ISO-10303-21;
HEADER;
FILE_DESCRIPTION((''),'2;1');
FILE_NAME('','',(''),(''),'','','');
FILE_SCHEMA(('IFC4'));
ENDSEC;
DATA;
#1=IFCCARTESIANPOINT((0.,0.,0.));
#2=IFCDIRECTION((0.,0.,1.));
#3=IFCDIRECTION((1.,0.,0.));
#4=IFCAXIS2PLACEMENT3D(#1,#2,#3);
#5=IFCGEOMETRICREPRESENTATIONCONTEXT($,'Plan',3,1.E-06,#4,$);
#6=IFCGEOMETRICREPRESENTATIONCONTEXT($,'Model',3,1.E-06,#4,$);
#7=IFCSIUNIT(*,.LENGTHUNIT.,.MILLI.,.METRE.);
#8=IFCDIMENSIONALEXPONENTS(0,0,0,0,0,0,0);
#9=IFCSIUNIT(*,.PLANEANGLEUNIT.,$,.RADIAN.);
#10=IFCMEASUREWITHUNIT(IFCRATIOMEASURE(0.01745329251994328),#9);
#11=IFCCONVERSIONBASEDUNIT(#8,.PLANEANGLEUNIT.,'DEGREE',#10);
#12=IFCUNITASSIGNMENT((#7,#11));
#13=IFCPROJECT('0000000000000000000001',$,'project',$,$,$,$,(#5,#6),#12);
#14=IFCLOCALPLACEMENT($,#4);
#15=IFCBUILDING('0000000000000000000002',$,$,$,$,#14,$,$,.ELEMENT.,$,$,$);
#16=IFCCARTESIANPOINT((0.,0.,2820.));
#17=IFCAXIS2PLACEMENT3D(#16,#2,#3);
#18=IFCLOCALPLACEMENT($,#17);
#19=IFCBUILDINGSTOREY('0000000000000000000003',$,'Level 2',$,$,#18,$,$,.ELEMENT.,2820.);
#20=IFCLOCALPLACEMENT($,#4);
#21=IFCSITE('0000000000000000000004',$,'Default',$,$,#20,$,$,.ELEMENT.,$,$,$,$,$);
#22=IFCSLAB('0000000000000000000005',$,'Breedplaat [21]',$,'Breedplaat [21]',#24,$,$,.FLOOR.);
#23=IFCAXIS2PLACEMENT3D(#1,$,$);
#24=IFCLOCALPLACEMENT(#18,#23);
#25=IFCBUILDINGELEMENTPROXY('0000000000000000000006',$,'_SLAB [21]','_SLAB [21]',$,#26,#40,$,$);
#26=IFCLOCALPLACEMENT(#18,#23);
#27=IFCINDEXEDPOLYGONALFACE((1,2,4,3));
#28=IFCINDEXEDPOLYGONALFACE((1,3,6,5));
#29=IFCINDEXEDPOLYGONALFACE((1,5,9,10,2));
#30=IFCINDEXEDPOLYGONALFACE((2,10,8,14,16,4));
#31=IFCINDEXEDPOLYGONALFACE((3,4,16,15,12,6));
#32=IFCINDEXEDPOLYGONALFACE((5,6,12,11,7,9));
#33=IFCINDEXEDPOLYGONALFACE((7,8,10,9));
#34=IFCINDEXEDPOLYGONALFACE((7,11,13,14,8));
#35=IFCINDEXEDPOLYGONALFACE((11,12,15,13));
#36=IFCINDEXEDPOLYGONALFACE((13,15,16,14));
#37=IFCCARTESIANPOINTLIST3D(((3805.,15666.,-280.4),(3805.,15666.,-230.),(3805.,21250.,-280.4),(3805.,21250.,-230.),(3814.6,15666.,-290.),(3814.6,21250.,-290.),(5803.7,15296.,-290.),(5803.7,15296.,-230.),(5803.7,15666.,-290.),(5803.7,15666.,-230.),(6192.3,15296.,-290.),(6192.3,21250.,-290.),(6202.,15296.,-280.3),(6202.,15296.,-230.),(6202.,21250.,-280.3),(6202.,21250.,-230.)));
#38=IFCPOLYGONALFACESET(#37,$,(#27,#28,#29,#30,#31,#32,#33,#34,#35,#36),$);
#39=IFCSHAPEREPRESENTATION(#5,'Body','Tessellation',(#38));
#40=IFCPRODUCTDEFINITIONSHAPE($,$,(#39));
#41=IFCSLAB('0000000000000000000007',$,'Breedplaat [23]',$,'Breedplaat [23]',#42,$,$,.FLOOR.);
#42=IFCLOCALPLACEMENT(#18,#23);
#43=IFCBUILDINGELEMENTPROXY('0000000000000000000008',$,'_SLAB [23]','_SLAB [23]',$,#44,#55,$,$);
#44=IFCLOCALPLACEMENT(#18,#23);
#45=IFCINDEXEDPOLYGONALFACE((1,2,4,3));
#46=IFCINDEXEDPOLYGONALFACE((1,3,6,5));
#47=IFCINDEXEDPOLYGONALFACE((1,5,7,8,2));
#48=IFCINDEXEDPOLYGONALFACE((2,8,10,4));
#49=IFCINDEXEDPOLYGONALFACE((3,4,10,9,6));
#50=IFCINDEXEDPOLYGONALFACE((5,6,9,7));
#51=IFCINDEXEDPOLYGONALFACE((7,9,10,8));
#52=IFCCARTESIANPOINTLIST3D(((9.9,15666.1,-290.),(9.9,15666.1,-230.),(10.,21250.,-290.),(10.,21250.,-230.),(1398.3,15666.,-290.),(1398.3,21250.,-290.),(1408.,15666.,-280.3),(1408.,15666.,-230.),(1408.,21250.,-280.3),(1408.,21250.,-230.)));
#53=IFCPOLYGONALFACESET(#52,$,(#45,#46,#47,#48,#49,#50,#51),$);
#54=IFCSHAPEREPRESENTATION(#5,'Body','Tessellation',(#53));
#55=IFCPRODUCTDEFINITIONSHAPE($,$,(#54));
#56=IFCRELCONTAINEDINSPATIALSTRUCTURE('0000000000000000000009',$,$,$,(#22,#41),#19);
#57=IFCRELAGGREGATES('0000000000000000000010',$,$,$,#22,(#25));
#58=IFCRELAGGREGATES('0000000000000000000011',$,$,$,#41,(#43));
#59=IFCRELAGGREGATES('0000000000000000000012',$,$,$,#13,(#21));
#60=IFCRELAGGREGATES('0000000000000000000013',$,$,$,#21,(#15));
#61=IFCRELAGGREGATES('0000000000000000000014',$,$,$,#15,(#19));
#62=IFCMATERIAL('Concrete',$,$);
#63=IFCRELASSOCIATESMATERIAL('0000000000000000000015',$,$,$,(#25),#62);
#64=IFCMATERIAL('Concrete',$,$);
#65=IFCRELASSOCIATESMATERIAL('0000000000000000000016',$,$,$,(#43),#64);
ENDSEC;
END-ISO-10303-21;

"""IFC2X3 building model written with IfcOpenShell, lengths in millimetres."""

from ifc_helpers import new_model, entity, si_unit, converted_unit, frame, origin_with_axes, place, context, project, spatial, polyline, outline, extrude, material, element, aggregate, save


model = new_model("IFC2X3")

# Units and contexts
plan_context = context("Plan", 3, precision=1e-06, world=origin_with_axes())
model_context = context("Model", 3, precision=1e-06, world=origin_with_axes())
ifc_project = project(units=[si_unit("LENGTHUNIT", "METRE", prefix="MILLI"), converted_unit("PLANEANGLEUNIT", "DEGREE", entity("IfcRatioMeasure", 0.01745329251994328), si_unit("PLANEANGLEUNIT", "RADIAN"), dimensions=[0, 0, 0, 0, 0, 0, 0])], contexts=[plan_context, model_context])

# Site, building, storey
site_placement = place(None, origin_with_axes())
site = spatial("IfcSite", under=ifc_project, at=site_placement, Name="Default", CompositionType="ELEMENT")
building_placement = place(None, origin_with_axes())
building = spatial("IfcBuilding", under=site, at=building_placement, CompositionType="ELEMENT")
storey_placement = place(None, frame((0.0, 0.0, 2820.0), z_axis=(0.0, 0.0, 1.0), x_axis=(1.0, 0.0, 0.0)))
storey = spatial("IfcBuildingStorey", under=building, at=storey_placement, Name="Level 2", CompositionType="ELEMENT", Elevation=2820.0)

# Slab, building element proxy, openings
slab_1_placement = place(None, frame((6202.0, 15296.0, 2530.0), z_axis=(0.0, 0.0, 1.0), x_axis=(0.0, 1.0, 0.0)))
slab_1 = element("IfcSlab", 1, at=slab_1_placement, inside=storey, Name="Breedplaat [21]", ObjectType="Breedplaat [21]", PredefinedType="FLOOR")
ifc_material_1 = material(Name="Concrete")
proxy_1_placement = place(slab_1_placement, origin_with_axes())
proxy_1 = element("IfcBuildingElementProxy", 2, at=proxy_1_placement, material=ifc_material_1, Name="_SLAB [21]", Description="_SLAB [21]", context=plan_context, shape_type="SweptSolid", body=[
    extrude(outline(polyline([(370.0, 2397.0), (370.0, 398.3), (0.0, 398.3), (0.0, 0.0), (5954.0, 0.0), (5954.0, 2397.0), (370.0, 2397.0)])), origin_with_axes(), (0.0, 0.0, 1.0), 60.0),
])
opening_1_placement = place(None, frame((6202.0, 15296.0, 2530.0), z_axis=(0.0, 0.0, 1.0), x_axis=(0.0, 1.0, 0.0)))
element("IfcOpeningElement", 3, at=opening_1_placement, cuts=proxy_1, ObjectType="Opening", context=plan_context, shape_type="SweptSolid", body=[
    extrude(outline(polyline([(-0.1, -0.1), (-0.1, 10.0), (10.0, -0.1), (-0.1, -0.1)])), frame((-1.2, -0.1, -0.1), z_axis=(1.0, 0.0, 0.0), x_axis=(0.0, 1.0, 0.0)), (0.0, 0.0, 1.0), 5956.2),
])
opening_2_placement = place(None, frame((6202.0, 15296.0, 2530.0), z_axis=(0.0, 0.0, 1.0), x_axis=(0.0, 1.0, 0.0)))
element("IfcOpeningElement", 4, at=opening_2_placement, cuts=proxy_1, ObjectType="Opening", context=plan_context, shape_type="SweptSolid", body=[
    extrude(outline(polyline([(-0.1, -0.1), (-0.1, 10.0), (10.0, -0.1), (-0.1, -0.1)])), frame((5955.2, 2397.2, -0.1), z_axis=(-1.0, 0.0, 0.0), x_axis=(0.0, -1.0, 0.0)), (0.0, 0.0, 1.0), 5586.2),
])
aggregate(slab_1, [proxy_1])

# Slab, building element proxy, opening
slab_2_placement = place(None, frame((1408.0, 15666.0, 2530.0), z_axis=(0.0, 0.0, 1.0), x_axis=(0.0, 1.0, 0.0)))
slab_2 = element("IfcSlab", 5, at=slab_2_placement, inside=storey, Name="Breedplaat [23]", ObjectType="Breedplaat [23]", PredefinedType="FLOOR")
ifc_material_2 = material(Name="Concrete")
proxy_2_placement = place(slab_2_placement, origin_with_axes())
proxy_2 = element("IfcBuildingElementProxy", 6, at=proxy_2_placement, material=ifc_material_2, Name="_SLAB [23]", Description="_SLAB [23]", context=plan_context, shape_type="SweptSolid", body=[
    extrude(outline(polyline([(0.0, 0.0), (5584.0, 0.0), (5584.0, 1398.0), (0.0, 1398.0), (0.0, 0.0)])), origin_with_axes(), (0.0, 0.0, 1.0), 60.0),
])
opening_3_placement = place(None, frame((1408.0, 15666.0, 2530.0), z_axis=(0.0, 0.0, 1.0), x_axis=(0.0, 1.0, 0.0)))
element("IfcOpeningElement", 7, at=opening_3_placement, cuts=proxy_2, ObjectType="Opening", context=plan_context, shape_type="SweptSolid", body=[
    extrude(outline(polyline([(-0.1, -0.1), (-0.1, 10.0), (10.0, -0.1), (-0.1, -0.1)])), frame((-1.2, -0.1, -0.1), z_axis=(1.0, 0.0, 0.0), x_axis=(0.0, 1.0, 0.0)), (0.0, 0.0, 1.0), 5586.2),
])
aggregate(slab_2, [proxy_2])

save(model, "model.ifc")
